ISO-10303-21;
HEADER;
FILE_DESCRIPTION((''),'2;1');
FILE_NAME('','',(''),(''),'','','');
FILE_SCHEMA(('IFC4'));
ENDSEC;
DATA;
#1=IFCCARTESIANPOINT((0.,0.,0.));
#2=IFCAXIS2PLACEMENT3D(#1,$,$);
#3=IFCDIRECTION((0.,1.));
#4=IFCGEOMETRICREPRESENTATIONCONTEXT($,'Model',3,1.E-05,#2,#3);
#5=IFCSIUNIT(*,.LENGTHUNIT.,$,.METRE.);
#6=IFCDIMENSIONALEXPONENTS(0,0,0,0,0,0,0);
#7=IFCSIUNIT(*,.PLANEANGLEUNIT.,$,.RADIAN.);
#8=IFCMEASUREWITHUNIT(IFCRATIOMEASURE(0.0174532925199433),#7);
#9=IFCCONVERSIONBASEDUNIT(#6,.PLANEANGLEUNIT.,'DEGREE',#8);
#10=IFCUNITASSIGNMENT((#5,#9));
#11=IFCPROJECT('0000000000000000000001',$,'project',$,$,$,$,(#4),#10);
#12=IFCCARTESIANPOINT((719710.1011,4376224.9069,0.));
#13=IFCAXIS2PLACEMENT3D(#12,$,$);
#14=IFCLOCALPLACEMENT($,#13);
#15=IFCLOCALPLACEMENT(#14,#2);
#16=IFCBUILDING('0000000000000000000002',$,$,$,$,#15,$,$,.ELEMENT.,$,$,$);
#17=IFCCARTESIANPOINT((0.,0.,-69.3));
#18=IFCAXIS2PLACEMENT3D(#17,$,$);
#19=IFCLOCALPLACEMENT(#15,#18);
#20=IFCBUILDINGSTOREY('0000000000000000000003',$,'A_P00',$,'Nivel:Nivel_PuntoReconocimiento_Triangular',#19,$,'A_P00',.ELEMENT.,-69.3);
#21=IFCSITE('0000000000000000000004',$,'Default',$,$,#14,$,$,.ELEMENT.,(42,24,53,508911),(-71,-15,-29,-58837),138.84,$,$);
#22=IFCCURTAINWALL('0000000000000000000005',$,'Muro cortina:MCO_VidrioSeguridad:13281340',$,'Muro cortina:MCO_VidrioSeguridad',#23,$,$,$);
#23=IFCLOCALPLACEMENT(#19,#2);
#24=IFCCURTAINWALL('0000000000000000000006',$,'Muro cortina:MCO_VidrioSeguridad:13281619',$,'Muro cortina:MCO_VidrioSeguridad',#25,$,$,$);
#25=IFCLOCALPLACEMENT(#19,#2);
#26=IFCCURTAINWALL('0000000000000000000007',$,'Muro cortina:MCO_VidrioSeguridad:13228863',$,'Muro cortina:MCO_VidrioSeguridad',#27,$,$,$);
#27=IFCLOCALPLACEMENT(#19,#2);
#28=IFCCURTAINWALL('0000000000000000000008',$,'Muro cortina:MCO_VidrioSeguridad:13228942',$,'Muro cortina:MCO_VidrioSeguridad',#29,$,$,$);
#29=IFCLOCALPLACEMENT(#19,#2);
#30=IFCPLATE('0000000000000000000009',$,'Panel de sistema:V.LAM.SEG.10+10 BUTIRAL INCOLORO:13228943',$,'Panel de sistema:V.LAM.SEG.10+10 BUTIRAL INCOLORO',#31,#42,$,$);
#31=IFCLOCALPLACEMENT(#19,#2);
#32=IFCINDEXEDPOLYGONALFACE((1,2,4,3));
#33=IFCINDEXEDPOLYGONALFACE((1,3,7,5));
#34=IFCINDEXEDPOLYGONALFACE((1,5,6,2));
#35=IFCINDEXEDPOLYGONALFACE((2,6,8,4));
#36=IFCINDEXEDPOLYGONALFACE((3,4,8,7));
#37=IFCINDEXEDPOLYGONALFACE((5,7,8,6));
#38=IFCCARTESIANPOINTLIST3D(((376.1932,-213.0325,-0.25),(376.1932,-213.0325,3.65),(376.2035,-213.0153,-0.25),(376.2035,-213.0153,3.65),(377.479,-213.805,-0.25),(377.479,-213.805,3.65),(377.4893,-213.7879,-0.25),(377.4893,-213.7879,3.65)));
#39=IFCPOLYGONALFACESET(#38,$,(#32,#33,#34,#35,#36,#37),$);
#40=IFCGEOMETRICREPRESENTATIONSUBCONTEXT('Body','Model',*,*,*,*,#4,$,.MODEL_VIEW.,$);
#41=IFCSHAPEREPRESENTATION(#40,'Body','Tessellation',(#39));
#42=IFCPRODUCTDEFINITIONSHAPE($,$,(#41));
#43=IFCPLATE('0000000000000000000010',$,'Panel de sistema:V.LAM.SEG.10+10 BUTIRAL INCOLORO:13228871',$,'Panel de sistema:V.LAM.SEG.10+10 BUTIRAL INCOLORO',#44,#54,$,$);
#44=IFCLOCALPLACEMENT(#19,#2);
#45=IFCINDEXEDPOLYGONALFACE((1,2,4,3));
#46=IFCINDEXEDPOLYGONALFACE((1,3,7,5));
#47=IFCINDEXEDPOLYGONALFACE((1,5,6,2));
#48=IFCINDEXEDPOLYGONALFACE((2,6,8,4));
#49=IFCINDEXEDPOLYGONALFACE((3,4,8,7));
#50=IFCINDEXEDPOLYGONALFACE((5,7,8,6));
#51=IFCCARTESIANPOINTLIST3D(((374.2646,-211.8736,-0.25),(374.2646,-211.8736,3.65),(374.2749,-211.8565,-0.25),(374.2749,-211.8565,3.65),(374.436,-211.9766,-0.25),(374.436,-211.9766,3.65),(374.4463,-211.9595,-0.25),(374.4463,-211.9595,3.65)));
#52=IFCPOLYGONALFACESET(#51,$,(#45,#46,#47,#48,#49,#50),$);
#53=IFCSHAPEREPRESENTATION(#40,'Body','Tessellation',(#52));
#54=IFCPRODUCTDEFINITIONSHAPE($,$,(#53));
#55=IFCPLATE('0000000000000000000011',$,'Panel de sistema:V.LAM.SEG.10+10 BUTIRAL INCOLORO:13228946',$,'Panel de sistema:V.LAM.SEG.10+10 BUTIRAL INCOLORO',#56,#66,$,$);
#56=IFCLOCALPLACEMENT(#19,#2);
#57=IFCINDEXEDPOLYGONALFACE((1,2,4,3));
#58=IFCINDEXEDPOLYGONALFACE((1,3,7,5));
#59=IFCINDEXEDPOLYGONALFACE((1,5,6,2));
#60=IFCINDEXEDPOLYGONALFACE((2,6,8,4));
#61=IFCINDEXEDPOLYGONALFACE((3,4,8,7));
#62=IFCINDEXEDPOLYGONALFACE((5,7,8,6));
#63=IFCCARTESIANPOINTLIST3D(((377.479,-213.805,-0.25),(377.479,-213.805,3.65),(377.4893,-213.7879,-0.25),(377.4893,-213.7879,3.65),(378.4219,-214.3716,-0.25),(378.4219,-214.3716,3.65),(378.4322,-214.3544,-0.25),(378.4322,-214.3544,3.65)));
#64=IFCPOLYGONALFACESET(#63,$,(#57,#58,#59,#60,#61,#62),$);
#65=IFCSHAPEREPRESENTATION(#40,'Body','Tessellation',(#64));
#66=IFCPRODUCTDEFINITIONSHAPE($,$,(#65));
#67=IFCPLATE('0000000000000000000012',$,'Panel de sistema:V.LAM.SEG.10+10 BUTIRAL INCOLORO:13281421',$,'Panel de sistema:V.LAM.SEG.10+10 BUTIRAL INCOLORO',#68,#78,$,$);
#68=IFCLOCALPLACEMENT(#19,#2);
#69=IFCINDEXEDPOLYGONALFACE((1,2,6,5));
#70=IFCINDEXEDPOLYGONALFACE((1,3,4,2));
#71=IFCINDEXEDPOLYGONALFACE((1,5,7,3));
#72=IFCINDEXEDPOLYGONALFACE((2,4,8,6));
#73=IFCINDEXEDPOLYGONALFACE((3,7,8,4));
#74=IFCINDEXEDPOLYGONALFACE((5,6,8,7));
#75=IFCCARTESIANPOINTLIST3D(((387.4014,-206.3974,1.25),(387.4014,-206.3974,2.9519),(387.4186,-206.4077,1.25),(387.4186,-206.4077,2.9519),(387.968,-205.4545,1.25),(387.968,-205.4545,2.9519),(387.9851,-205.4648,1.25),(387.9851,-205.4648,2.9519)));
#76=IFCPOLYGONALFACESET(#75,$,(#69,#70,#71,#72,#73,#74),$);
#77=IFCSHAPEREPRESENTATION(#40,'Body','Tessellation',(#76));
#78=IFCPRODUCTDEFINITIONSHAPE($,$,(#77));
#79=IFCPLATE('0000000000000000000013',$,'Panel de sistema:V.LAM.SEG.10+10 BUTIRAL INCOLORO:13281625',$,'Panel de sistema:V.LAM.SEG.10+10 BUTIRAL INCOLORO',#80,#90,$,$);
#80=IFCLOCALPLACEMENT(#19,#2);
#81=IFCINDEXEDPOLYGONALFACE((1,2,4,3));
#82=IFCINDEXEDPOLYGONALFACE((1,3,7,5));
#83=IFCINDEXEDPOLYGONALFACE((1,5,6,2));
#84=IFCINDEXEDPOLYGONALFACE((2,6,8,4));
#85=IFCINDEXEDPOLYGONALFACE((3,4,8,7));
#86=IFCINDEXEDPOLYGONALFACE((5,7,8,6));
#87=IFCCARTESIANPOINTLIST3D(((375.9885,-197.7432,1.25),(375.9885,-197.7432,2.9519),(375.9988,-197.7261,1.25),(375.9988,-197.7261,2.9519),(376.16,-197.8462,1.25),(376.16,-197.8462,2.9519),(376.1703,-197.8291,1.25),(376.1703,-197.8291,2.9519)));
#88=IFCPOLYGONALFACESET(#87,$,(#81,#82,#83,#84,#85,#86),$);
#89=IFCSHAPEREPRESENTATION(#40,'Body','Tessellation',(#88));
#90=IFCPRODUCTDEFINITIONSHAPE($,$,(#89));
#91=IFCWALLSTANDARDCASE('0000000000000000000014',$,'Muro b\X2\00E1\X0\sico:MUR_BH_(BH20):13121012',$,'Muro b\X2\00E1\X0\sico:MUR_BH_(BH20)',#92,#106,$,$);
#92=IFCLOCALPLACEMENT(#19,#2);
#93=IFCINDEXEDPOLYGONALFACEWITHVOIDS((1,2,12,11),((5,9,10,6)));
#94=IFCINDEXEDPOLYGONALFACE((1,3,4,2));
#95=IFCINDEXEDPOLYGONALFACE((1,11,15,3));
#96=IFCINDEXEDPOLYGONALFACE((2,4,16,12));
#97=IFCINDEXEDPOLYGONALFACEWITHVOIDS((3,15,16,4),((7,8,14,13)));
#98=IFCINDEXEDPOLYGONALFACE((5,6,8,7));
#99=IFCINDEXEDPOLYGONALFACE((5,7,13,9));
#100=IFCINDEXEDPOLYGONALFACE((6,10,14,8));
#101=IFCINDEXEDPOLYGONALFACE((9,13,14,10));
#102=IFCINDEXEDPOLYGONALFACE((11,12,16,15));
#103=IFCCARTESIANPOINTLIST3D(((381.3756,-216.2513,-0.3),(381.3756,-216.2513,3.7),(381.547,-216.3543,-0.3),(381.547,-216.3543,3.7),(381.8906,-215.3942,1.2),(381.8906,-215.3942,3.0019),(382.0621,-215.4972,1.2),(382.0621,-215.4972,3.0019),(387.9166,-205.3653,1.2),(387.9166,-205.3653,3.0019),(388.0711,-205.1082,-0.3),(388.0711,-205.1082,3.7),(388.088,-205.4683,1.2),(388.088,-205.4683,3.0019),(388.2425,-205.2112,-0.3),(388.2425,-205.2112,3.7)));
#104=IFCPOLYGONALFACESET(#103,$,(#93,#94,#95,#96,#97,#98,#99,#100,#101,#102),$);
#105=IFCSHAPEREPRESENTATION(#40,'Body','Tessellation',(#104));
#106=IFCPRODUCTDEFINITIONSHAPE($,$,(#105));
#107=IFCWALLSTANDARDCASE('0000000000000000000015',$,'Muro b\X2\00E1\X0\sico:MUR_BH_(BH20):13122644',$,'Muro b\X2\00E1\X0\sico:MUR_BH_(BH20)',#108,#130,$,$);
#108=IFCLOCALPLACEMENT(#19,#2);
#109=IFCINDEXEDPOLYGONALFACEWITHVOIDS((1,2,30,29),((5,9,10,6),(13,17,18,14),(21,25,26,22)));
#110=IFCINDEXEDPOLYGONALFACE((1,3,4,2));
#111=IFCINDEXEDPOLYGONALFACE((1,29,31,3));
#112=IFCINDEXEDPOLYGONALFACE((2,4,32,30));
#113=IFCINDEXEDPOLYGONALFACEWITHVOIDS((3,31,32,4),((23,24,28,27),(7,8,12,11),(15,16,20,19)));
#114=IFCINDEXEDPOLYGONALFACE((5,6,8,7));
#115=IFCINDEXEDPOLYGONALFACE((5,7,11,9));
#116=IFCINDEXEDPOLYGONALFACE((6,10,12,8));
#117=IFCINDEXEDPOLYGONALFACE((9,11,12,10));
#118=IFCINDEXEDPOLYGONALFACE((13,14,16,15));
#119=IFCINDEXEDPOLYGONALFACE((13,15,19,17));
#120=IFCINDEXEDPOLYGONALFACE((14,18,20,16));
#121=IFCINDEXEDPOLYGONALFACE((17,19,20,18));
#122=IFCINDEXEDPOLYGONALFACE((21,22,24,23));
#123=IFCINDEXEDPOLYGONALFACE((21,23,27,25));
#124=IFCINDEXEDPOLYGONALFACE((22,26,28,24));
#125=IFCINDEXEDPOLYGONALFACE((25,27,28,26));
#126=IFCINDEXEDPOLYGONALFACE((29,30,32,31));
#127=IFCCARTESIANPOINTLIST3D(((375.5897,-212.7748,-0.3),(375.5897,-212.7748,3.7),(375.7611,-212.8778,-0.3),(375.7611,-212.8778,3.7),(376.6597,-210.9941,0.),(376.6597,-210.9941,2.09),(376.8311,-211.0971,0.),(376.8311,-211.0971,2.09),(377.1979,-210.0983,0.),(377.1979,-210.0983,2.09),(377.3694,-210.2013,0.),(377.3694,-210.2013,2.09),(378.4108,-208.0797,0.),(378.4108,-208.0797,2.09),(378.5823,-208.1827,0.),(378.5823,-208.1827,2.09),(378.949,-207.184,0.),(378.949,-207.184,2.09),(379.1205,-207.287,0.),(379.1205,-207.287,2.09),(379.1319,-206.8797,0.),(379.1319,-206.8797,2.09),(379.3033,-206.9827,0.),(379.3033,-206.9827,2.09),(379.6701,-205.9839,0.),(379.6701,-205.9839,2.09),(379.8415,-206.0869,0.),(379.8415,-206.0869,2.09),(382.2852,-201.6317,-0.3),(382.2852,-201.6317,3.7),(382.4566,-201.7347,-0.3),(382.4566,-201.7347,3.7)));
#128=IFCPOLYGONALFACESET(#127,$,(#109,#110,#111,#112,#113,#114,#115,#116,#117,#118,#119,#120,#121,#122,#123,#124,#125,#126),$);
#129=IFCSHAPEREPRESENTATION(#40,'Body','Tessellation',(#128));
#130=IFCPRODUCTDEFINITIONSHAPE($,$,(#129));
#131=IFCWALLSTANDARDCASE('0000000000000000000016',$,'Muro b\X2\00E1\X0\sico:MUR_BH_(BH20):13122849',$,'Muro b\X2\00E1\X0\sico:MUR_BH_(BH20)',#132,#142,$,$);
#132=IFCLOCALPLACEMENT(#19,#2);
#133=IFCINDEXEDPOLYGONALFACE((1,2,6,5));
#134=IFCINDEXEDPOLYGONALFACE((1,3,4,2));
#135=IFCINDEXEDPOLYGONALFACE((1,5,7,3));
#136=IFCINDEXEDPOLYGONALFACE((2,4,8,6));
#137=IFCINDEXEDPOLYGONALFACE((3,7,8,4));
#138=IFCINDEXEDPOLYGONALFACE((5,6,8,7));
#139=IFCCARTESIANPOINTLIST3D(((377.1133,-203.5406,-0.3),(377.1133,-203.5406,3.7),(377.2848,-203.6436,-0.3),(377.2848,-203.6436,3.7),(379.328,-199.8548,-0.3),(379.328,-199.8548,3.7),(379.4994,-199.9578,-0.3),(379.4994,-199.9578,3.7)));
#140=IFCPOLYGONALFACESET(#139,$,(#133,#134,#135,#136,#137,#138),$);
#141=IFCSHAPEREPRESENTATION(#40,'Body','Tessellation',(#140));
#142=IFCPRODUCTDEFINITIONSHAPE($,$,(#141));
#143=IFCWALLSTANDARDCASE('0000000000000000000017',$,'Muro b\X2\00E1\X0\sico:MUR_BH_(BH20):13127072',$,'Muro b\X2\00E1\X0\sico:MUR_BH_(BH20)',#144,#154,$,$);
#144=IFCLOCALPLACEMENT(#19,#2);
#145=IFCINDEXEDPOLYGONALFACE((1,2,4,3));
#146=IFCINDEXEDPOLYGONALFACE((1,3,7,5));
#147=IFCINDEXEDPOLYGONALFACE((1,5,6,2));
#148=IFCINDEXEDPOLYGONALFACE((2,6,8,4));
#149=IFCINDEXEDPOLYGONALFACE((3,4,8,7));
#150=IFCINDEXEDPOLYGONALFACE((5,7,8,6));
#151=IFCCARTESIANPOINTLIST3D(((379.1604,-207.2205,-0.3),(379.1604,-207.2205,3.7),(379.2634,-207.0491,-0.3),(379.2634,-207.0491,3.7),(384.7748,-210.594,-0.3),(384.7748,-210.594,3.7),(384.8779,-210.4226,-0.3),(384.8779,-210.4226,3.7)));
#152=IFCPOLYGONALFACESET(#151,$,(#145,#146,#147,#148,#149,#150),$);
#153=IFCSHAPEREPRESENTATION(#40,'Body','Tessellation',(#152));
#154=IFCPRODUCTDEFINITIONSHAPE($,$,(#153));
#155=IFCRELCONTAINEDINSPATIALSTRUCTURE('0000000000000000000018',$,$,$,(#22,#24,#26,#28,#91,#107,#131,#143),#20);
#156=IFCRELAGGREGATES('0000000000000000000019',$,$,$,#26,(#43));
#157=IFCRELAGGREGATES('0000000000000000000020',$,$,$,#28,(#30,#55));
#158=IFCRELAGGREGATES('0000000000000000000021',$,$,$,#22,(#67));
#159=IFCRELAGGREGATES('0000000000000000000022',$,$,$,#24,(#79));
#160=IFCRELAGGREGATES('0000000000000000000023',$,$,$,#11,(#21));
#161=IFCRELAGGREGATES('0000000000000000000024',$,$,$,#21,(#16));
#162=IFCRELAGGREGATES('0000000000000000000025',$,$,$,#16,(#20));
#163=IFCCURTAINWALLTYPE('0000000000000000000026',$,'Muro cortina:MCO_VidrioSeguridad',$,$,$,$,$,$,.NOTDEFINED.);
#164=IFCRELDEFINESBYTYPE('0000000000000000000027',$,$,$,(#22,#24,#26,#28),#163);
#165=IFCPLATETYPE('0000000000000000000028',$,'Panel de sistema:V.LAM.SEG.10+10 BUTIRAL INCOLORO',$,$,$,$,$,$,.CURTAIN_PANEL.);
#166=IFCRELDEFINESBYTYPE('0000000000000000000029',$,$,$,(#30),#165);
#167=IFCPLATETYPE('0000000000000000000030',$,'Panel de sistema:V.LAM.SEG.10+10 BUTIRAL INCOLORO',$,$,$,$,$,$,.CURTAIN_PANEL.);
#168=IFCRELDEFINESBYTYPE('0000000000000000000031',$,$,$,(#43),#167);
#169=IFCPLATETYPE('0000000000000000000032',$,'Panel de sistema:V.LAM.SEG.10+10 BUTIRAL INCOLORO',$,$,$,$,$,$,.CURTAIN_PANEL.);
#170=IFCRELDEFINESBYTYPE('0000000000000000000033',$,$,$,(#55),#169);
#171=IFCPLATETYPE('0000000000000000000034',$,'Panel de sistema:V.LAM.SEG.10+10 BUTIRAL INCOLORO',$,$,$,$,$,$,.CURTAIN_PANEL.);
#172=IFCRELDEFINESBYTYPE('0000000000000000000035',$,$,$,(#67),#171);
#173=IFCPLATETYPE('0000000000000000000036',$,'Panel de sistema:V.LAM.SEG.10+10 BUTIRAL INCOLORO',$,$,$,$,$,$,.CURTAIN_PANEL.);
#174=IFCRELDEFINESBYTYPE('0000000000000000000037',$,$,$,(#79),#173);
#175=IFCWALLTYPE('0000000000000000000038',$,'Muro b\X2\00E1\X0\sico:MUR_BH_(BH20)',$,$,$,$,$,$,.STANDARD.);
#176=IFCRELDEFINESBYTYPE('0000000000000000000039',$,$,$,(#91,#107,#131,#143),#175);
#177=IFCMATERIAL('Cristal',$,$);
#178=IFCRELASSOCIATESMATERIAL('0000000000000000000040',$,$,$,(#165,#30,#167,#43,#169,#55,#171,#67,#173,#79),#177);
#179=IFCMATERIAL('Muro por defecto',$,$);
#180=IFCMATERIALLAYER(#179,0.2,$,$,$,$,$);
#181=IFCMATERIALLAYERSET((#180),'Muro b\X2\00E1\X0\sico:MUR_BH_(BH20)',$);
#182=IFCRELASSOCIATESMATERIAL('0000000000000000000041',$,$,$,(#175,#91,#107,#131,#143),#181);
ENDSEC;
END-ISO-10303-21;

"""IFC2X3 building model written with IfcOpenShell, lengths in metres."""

from ifc_helpers import new_model, entity, si_unit, converted_unit, direction, frame, frame_2d, origin, origin_2d_with_axis, place, context, subcontext, project, spatial, rectangle, extrude, source, transform, mapped, material, layer, layer_set, layer_usage, type_object, type_shapes, element, aggregate, save


model = new_model("IFC2X3")

# Units and contexts
model_context = context("Model", 3, precision=1e-05, world=origin(), true_north=direction((0.0, 1.0)))
body_context = subcontext(model_context, "Body", "Model", "MODEL_VIEW")
ifc_project = project(units=[si_unit("LENGTHUNIT", "METRE"), converted_unit("PLANEANGLEUNIT", "DEGREE", entity("IfcRatioMeasure", 0.0174532925199433), si_unit("PLANEANGLEUNIT", "RADIAN"), dimensions=[0, 0, 0, 0, 0, 0, 0])], contexts=[model_context])

# Site, building, storey
site_placement = place(None, frame((719710.1011, 4376224.9069, 0.0)))
site = spatial("IfcSite", under=ifc_project, at=site_placement, Name="Default", CompositionType="ELEMENT", RefLatitude=(42, 24, 53, 508911), RefLongitude=(-71, -15, -29, -58837), RefElevation=138.84)
building_placement = place(site_placement, origin())
building = spatial("IfcBuilding", under=site, at=building_placement, CompositionType="ELEMENT")
storey_placement = place(building_placement, frame((0.0, 0.0, -69.3)))
storey = spatial("IfcBuildingStorey", under=building, at=storey_placement, Name="A_P00", ObjectType="Nivel:Nivel_PuntoReconocimiento_Triangular", LongName="A_P00", CompositionType="ELEMENT", Elevation=-69.3)

# Curtain walls
curtain_wall_type = type_object("IfcCurtainWallType", Name="Muro cortina:MCO_VidrioSeguridad", PredefinedType="NOTDEFINED")
ifc_material_1 = material(Name="Cristal")
curtain_wall_1_placement = place(storey_placement, frame((0.0, 0.0, 69.3)))
curtain_wall_1 = element("IfcCurtainWall", 1, at=curtain_wall_1_placement, inside=storey, type_object=curtain_wall_type, Name="Muro cortina:MCO_VidrioSeguridad:13281340", ObjectType="Muro cortina:MCO_VidrioSeguridad")
curtain_wall_2_placement = place(storey_placement, frame((0.0, 0.0, 69.3)))
curtain_wall_2 = element("IfcCurtainWall", 2, at=curtain_wall_2_placement, inside=storey, type_object=curtain_wall_type, Name="Muro cortina:MCO_VidrioSeguridad:13281619", ObjectType="Muro cortina:MCO_VidrioSeguridad")
curtain_wall_3_placement = place(storey_placement, frame((0.0, 0.0, 69.3)))
curtain_wall_3 = element("IfcCurtainWall", 3, at=curtain_wall_3_placement, inside=storey, type_object=curtain_wall_type, Name="Muro cortina:MCO_VidrioSeguridad:13228863", ObjectType="Muro cortina:MCO_VidrioSeguridad")
plate_type_1 = type_object("IfcPlateType", Name="Panel de sistema:V.LAM.SEG.10+10 BUTIRAL INCOLORO", PredefinedType="CURTAIN_PANEL", material=ifc_material_1)
shared_shape_1 = source(origin(), body_context, "Body", "SweptSolid", [
    extrude(rectangle(XDim=0.02, YDim=1.5, at=origin_2d_with_axis()), frame((0.0, 0.0, 0.0), z_axis=(0.0, 0.0, 1.0), x_axis=(0.0, 1.0, 0.0)), (0.0, 0.0, 1.0), 3.9),
])
type_shapes(plate_type_1, [shared_shape_1])

# Curtain wall, plate
curtain_wall_4_placement = place(storey_placement, frame((0.0, 0.0, 69.3)))
curtain_wall_4 = element("IfcCurtainWall", 4, at=curtain_wall_4_placement, inside=storey, type_object=curtain_wall_type, Name="Muro cortina:MCO_VidrioSeguridad:13228942", ObjectType="Muro cortina:MCO_VidrioSeguridad")
plate_1_placement = place(curtain_wall_4_placement, frame((376.8413, -213.4102, -69.55), z_axis=(0.0, 0.0, 1.0), x_axis=(0.857167, -0.515038, 0.0)))
plate_1 = element("IfcPlate", 5, at=plate_1_placement, type_object=plate_type_1, material=ifc_material_1, Name="Panel de sistema:V.LAM.SEG.10+10 BUTIRAL INCOLORO:13228943", ObjectType="Panel de sistema:V.LAM.SEG.10+10 BUTIRAL INCOLORO", context=body_context, shape_type="MappedRepresentation", body=[
    mapped(shared_shape_1, transform((0.0, 0.0, 0.0), scale=1.0)),
])

# Plates
plate_type_2 = type_object("IfcPlateType", Name="Panel de sistema:V.LAM.SEG.10+10 BUTIRAL INCOLORO", PredefinedType="CURTAIN_PANEL", material=ifc_material_1)
shared_shape_2 = source(origin(), body_context, "Body", "SweptSolid", [
    extrude(rectangle(XDim=0.02, YDim=0.2, at=origin_2d_with_axis()), frame((0.0, 0.0, 0.0), z_axis=(0.0, 0.0, 1.0), x_axis=(0.0, 1.0, 0.0)), (0.0, 0.0, 1.0), 3.9),
])
type_shapes(plate_type_2, [shared_shape_2])
plate_2_placement = place(curtain_wall_3_placement, frame((374.3555, -211.9166, -69.55), z_axis=(0.0, 0.0, 1.0), x_axis=(0.857167, -0.515038, 0.0)))
plate_2 = element("IfcPlate", 6, at=plate_2_placement, type_object=plate_type_2, material=ifc_material_1, Name="Panel de sistema:V.LAM.SEG.10+10 BUTIRAL INCOLORO:13228871", ObjectType="Panel de sistema:V.LAM.SEG.10+10 BUTIRAL INCOLORO", context=body_context, shape_type="MappedRepresentation", body=[
    mapped(shared_shape_2, transform((0.0, 0.0, 0.0), scale=1.0)),
])
aggregate(curtain_wall_3, [plate_2])
plate_type_3 = type_object("IfcPlateType", Name="Panel de sistema:V.LAM.SEG.10+10 BUTIRAL INCOLORO", PredefinedType="CURTAIN_PANEL", material=ifc_material_1)
shared_shape_3 = source(origin(), body_context, "Body", "SweptSolid", [
    extrude(rectangle(XDim=0.02, YDim=1.1, at=origin_2d_with_axis()), frame((0.0, 0.0, 0.0), z_axis=(0.0, 0.0, 1.0), x_axis=(0.0, 1.0, 0.0)), (0.0, 0.0, 1.0), 3.9),
])
type_shapes(plate_type_3, [shared_shape_3])
plate_3_placement = place(curtain_wall_4_placement, frame((377.9556, -214.0797, -69.55), z_axis=(0.0, 0.0, 1.0), x_axis=(0.857167, -0.515038, 0.0)))
plate_3 = element("IfcPlate", 7, at=plate_3_placement, type_object=plate_type_3, material=ifc_material_1, Name="Panel de sistema:V.LAM.SEG.10+10 BUTIRAL INCOLORO:13228946", ObjectType="Panel de sistema:V.LAM.SEG.10+10 BUTIRAL INCOLORO", context=body_context, shape_type="MappedRepresentation", body=[
    mapped(shared_shape_3, transform((0.0, 0.0, 0.0), scale=1.0)),
])
aggregate(curtain_wall_4, [plate_1, plate_3])
plate_type_4 = type_object("IfcPlateType", Name="Panel de sistema:V.LAM.SEG.10+10 BUTIRAL INCOLORO", PredefinedType="CURTAIN_PANEL", material=ifc_material_1)
shared_shape_4 = source(origin(), body_context, "Body", "SweptSolid", [
    extrude(rectangle(XDim=0.02, YDim=1.1, at=origin_2d_with_axis()), frame((0.0, 0.0, 0.0), z_axis=(0.0, 0.0, 1.0), x_axis=(0.0, 1.0, 0.0)), (0.0, 0.0, 1.0), 1.7019),
])
type_shapes(plate_type_4, [shared_shape_4])
plate_4_placement = place(curtain_wall_1_placement, frame((387.6933, -205.9311, -68.05), z_axis=(0.0, 0.0, 1.0), x_axis=(0.515038, 0.857167, 0.0)))
plate_4 = element("IfcPlate", 8, at=plate_4_placement, type_object=plate_type_4, material=ifc_material_1, Name="Panel de sistema:V.LAM.SEG.10+10 BUTIRAL INCOLORO:13281421", ObjectType="Panel de sistema:V.LAM.SEG.10+10 BUTIRAL INCOLORO", context=body_context, shape_type="MappedRepresentation", body=[
    mapped(shared_shape_4, transform((0.0, 0.0, 0.0), scale=1.0)),
])
aggregate(curtain_wall_1, [plate_4])
plate_type_5 = type_object("IfcPlateType", Name="Panel de sistema:V.LAM.SEG.10+10 BUTIRAL INCOLORO", PredefinedType="CURTAIN_PANEL", material=ifc_material_1)
shared_shape_5 = source(origin(), body_context, "Body", "SweptSolid", [
    extrude(rectangle(XDim=0.02, YDim=0.2, at=origin_2d_with_axis()), frame((0.0, 0.0, 0.0), z_axis=(0.0, 0.0, 1.0), x_axis=(0.0, 1.0, 0.0)), (0.0, 0.0, 1.0), 1.7019),
])
type_shapes(plate_type_5, [shared_shape_5])
plate_5_placement = place(curtain_wall_2_placement, frame((376.0794, -197.7862, -68.05), z_axis=(0.0, 0.0, 1.0), x_axis=(0.857167, -0.515038, 0.0)))
plate_5 = element("IfcPlate", 9, at=plate_5_placement, type_object=plate_type_5, material=ifc_material_1, Name="Panel de sistema:V.LAM.SEG.10+10 BUTIRAL INCOLORO:13281625", ObjectType="Panel de sistema:V.LAM.SEG.10+10 BUTIRAL INCOLORO", context=body_context, shape_type="MappedRepresentation", body=[
    mapped(shared_shape_5, transform((0.0, 0.0, 0.0), scale=1.0)),
])
aggregate(curtain_wall_2, [plate_5])

# Wall, opening
ifc_material_2 = material(Name="Muro por defecto")
ifc_layer = layer(ifc_material_2, 0.2)
ifc_layer_set = layer_set([ifc_layer], Name="Muro básico:MUR_BH_(BH20)")
ifc_layer_usage_1 = layer_usage(ifc_layer_set, "AXIS2", "NEGATIVE", 0.1)
wall_type = type_object("IfcWallType", Name="Muro básico:MUR_BH_(BH20)", PredefinedType="STANDARD", material=ifc_layer_set)
wall_1_placement = place(storey_placement, frame((388.1568, -205.1597, -0.3), z_axis=(0.0, 0.0, 1.0), x_axis=(-0.515038, -0.857167, 0.0)))
wall_1 = element("IfcWallStandardCase", 10, at=wall_1_placement, inside=storey, type_object=wall_type, material=ifc_layer_usage_1, Name="Muro básico:MUR_BH_(BH20):13121012", ObjectType="Muro básico:MUR_BH_(BH20)", context=body_context, shape_type="SweptSolid", body=[
    extrude(rectangle(XDim=13.0, YDim=0.2, at=frame_2d((6.5, 0.0), x_axis=(-1.0, 0.0))), origin(), (0.0, 0.0, 1.0), 4.0),
])
opening_1_placement = place(wall_1_placement, origin())
element("IfcOpeningElement", 11, at=opening_1_placement, cuts=wall_1, ObjectType="Opening", context=body_context, shape_type="SweptSolid", body=[
    extrude(rectangle(XDim=1.8019, YDim=11.7, at=frame_2d((0.0, 0.0), x_axis=(0.0, 1.0))), frame((6.15, -0.2524, 2.4009), z_axis=(0.0, 1.0, 0.0), x_axis=(-1.0, 0.0, 0.0)), (0.0, 0.0, 1.0), 0.5048),
])

# Wall, openings
ifc_layer_usage_2 = layer_usage(ifc_layer_set, "AXIS2", "NEGATIVE", 0.1)
wall_2_placement = place(storey_placement, frame((382.3709, -201.6832, -0.3), z_axis=(0.0, 0.0, 1.0), x_axis=(-0.515038, -0.857167, 0.0)))
wall_2 = element("IfcWallStandardCase", 12, at=wall_2_placement, inside=storey, type_object=wall_type, material=ifc_layer_usage_2, Name="Muro básico:MUR_BH_(BH20):13122644", ObjectType="Muro básico:MUR_BH_(BH20)", context=body_context, shape_type="SweptSolid", body=[
    extrude(rectangle(XDim=13.0, YDim=0.2, at=frame_2d((6.5, 0.0), x_axis=(-1.0, 0.0))), origin(), (0.0, 0.0, 1.0), 4.0),
])
opening_2_placement = place(wall_2_placement, frame((24.0594, -431.6304, 0.3), z_axis=(0.0, 0.0, 1.0), x_axis=(-0.515038, 0.857167, 0.0)))
element("IfcOpeningElement", 13, at=opening_2_placement, cuts=wall_2, ObjectType="Opening", context=body_context, shape_type="SweptSolid", body=[
    extrude(rectangle(XDim=2.09, YDim=1.045, at=frame_2d((0.0, 0.0), x_axis=(1.0, 0.0))), frame((379.401, -206.4318, 1.045), z_axis=(0.857167, -0.515038, 0.0), x_axis=(0.0, 0.0, -1.0)), (0.0, 0.0, 1.0), 0.2),
])
opening_3_placement = place(wall_2_placement, frame((24.0594, -431.6304, 0.3), z_axis=(0.0, 0.0, 1.0), x_axis=(-0.515038, 0.857167, 0.0)))
element("IfcOpeningElement", 14, at=opening_3_placement, cuts=wall_2, ObjectType="Opening", context=body_context, shape_type="SweptSolid", body=[
    extrude(rectangle(XDim=2.09, YDim=1.045, at=frame_2d((0.0, 0.0), x_axis=(0.0, 1.0))), frame((378.6799, -207.6318, 1.045), z_axis=(0.857167, -0.515038, 0.0), x_axis=(-0.515038, -0.857167, 0.0)), (0.0, 0.0, 1.0), 0.2),
])
opening_4_placement = place(wall_2_placement, frame((24.0594, -431.6304, 0.3), z_axis=(0.0, 0.0, 1.0), x_axis=(-0.515038, 0.857167, 0.0)))
element("IfcOpeningElement", 15, at=opening_4_placement, cuts=wall_2, ObjectType="Opening", context=body_context, shape_type="SweptSolid", body=[
    extrude(rectangle(XDim=2.09, YDim=1.045, at=frame_2d((0.0, 0.0), x_axis=(0.0, 1.0))), frame((376.9288, -210.5462, 1.045), z_axis=(0.857167, -0.515038, 0.0), x_axis=(-0.515038, -0.857167, 0.0)), (0.0, 0.0, 1.0), 0.2),
])

# Walls
ifc_layer_usage_3 = layer_usage(ifc_layer_set, "AXIS2", "NEGATIVE", 0.1)
wall_3_placement = place(storey_placement, frame((377.199, -203.5921, -0.3), z_axis=(0.0, 0.0, 1.0), x_axis=(0.515038, 0.857167, 0.0)))
element("IfcWallStandardCase", 16, at=wall_3_placement, inside=storey, type_object=wall_type, material=ifc_layer_usage_3, Name="Muro básico:MUR_BH_(BH20):13122849", ObjectType="Muro básico:MUR_BH_(BH20)", context=body_context, shape_type="SweptSolid", body=[
    extrude(rectangle(XDim=4.3, YDim=0.2, at=frame_2d((2.15, 0.0), x_axis=(-1.0, 0.0))), origin(), (0.0, 0.0, 1.0), 4.0),
])
ifc_layer_usage_4 = layer_usage(ifc_layer_set, "AXIS2", "NEGATIVE", 0.1)
wall_4_placement = place(storey_placement, frame((384.8263, -210.5083, -0.3), z_axis=(0.0, 0.0, 1.0), x_axis=(-0.857167, 0.515038, 0.0)))
element("IfcWallStandardCase", 17, at=wall_4_placement, inside=storey, type_object=wall_type, material=ifc_layer_usage_4, Name="Muro básico:MUR_BH_(BH20):13127072", ObjectType="Muro básico:MUR_BH_(BH20)", context=body_context, shape_type="SweptSolid", body=[
    extrude(rectangle(XDim=6.55, YDim=0.2, at=frame_2d((3.275, 0.0), x_axis=(-1.0, 0.0))), origin(), (0.0, 0.0, 1.0), 4.0),
])

save(model, "model.ifc")
